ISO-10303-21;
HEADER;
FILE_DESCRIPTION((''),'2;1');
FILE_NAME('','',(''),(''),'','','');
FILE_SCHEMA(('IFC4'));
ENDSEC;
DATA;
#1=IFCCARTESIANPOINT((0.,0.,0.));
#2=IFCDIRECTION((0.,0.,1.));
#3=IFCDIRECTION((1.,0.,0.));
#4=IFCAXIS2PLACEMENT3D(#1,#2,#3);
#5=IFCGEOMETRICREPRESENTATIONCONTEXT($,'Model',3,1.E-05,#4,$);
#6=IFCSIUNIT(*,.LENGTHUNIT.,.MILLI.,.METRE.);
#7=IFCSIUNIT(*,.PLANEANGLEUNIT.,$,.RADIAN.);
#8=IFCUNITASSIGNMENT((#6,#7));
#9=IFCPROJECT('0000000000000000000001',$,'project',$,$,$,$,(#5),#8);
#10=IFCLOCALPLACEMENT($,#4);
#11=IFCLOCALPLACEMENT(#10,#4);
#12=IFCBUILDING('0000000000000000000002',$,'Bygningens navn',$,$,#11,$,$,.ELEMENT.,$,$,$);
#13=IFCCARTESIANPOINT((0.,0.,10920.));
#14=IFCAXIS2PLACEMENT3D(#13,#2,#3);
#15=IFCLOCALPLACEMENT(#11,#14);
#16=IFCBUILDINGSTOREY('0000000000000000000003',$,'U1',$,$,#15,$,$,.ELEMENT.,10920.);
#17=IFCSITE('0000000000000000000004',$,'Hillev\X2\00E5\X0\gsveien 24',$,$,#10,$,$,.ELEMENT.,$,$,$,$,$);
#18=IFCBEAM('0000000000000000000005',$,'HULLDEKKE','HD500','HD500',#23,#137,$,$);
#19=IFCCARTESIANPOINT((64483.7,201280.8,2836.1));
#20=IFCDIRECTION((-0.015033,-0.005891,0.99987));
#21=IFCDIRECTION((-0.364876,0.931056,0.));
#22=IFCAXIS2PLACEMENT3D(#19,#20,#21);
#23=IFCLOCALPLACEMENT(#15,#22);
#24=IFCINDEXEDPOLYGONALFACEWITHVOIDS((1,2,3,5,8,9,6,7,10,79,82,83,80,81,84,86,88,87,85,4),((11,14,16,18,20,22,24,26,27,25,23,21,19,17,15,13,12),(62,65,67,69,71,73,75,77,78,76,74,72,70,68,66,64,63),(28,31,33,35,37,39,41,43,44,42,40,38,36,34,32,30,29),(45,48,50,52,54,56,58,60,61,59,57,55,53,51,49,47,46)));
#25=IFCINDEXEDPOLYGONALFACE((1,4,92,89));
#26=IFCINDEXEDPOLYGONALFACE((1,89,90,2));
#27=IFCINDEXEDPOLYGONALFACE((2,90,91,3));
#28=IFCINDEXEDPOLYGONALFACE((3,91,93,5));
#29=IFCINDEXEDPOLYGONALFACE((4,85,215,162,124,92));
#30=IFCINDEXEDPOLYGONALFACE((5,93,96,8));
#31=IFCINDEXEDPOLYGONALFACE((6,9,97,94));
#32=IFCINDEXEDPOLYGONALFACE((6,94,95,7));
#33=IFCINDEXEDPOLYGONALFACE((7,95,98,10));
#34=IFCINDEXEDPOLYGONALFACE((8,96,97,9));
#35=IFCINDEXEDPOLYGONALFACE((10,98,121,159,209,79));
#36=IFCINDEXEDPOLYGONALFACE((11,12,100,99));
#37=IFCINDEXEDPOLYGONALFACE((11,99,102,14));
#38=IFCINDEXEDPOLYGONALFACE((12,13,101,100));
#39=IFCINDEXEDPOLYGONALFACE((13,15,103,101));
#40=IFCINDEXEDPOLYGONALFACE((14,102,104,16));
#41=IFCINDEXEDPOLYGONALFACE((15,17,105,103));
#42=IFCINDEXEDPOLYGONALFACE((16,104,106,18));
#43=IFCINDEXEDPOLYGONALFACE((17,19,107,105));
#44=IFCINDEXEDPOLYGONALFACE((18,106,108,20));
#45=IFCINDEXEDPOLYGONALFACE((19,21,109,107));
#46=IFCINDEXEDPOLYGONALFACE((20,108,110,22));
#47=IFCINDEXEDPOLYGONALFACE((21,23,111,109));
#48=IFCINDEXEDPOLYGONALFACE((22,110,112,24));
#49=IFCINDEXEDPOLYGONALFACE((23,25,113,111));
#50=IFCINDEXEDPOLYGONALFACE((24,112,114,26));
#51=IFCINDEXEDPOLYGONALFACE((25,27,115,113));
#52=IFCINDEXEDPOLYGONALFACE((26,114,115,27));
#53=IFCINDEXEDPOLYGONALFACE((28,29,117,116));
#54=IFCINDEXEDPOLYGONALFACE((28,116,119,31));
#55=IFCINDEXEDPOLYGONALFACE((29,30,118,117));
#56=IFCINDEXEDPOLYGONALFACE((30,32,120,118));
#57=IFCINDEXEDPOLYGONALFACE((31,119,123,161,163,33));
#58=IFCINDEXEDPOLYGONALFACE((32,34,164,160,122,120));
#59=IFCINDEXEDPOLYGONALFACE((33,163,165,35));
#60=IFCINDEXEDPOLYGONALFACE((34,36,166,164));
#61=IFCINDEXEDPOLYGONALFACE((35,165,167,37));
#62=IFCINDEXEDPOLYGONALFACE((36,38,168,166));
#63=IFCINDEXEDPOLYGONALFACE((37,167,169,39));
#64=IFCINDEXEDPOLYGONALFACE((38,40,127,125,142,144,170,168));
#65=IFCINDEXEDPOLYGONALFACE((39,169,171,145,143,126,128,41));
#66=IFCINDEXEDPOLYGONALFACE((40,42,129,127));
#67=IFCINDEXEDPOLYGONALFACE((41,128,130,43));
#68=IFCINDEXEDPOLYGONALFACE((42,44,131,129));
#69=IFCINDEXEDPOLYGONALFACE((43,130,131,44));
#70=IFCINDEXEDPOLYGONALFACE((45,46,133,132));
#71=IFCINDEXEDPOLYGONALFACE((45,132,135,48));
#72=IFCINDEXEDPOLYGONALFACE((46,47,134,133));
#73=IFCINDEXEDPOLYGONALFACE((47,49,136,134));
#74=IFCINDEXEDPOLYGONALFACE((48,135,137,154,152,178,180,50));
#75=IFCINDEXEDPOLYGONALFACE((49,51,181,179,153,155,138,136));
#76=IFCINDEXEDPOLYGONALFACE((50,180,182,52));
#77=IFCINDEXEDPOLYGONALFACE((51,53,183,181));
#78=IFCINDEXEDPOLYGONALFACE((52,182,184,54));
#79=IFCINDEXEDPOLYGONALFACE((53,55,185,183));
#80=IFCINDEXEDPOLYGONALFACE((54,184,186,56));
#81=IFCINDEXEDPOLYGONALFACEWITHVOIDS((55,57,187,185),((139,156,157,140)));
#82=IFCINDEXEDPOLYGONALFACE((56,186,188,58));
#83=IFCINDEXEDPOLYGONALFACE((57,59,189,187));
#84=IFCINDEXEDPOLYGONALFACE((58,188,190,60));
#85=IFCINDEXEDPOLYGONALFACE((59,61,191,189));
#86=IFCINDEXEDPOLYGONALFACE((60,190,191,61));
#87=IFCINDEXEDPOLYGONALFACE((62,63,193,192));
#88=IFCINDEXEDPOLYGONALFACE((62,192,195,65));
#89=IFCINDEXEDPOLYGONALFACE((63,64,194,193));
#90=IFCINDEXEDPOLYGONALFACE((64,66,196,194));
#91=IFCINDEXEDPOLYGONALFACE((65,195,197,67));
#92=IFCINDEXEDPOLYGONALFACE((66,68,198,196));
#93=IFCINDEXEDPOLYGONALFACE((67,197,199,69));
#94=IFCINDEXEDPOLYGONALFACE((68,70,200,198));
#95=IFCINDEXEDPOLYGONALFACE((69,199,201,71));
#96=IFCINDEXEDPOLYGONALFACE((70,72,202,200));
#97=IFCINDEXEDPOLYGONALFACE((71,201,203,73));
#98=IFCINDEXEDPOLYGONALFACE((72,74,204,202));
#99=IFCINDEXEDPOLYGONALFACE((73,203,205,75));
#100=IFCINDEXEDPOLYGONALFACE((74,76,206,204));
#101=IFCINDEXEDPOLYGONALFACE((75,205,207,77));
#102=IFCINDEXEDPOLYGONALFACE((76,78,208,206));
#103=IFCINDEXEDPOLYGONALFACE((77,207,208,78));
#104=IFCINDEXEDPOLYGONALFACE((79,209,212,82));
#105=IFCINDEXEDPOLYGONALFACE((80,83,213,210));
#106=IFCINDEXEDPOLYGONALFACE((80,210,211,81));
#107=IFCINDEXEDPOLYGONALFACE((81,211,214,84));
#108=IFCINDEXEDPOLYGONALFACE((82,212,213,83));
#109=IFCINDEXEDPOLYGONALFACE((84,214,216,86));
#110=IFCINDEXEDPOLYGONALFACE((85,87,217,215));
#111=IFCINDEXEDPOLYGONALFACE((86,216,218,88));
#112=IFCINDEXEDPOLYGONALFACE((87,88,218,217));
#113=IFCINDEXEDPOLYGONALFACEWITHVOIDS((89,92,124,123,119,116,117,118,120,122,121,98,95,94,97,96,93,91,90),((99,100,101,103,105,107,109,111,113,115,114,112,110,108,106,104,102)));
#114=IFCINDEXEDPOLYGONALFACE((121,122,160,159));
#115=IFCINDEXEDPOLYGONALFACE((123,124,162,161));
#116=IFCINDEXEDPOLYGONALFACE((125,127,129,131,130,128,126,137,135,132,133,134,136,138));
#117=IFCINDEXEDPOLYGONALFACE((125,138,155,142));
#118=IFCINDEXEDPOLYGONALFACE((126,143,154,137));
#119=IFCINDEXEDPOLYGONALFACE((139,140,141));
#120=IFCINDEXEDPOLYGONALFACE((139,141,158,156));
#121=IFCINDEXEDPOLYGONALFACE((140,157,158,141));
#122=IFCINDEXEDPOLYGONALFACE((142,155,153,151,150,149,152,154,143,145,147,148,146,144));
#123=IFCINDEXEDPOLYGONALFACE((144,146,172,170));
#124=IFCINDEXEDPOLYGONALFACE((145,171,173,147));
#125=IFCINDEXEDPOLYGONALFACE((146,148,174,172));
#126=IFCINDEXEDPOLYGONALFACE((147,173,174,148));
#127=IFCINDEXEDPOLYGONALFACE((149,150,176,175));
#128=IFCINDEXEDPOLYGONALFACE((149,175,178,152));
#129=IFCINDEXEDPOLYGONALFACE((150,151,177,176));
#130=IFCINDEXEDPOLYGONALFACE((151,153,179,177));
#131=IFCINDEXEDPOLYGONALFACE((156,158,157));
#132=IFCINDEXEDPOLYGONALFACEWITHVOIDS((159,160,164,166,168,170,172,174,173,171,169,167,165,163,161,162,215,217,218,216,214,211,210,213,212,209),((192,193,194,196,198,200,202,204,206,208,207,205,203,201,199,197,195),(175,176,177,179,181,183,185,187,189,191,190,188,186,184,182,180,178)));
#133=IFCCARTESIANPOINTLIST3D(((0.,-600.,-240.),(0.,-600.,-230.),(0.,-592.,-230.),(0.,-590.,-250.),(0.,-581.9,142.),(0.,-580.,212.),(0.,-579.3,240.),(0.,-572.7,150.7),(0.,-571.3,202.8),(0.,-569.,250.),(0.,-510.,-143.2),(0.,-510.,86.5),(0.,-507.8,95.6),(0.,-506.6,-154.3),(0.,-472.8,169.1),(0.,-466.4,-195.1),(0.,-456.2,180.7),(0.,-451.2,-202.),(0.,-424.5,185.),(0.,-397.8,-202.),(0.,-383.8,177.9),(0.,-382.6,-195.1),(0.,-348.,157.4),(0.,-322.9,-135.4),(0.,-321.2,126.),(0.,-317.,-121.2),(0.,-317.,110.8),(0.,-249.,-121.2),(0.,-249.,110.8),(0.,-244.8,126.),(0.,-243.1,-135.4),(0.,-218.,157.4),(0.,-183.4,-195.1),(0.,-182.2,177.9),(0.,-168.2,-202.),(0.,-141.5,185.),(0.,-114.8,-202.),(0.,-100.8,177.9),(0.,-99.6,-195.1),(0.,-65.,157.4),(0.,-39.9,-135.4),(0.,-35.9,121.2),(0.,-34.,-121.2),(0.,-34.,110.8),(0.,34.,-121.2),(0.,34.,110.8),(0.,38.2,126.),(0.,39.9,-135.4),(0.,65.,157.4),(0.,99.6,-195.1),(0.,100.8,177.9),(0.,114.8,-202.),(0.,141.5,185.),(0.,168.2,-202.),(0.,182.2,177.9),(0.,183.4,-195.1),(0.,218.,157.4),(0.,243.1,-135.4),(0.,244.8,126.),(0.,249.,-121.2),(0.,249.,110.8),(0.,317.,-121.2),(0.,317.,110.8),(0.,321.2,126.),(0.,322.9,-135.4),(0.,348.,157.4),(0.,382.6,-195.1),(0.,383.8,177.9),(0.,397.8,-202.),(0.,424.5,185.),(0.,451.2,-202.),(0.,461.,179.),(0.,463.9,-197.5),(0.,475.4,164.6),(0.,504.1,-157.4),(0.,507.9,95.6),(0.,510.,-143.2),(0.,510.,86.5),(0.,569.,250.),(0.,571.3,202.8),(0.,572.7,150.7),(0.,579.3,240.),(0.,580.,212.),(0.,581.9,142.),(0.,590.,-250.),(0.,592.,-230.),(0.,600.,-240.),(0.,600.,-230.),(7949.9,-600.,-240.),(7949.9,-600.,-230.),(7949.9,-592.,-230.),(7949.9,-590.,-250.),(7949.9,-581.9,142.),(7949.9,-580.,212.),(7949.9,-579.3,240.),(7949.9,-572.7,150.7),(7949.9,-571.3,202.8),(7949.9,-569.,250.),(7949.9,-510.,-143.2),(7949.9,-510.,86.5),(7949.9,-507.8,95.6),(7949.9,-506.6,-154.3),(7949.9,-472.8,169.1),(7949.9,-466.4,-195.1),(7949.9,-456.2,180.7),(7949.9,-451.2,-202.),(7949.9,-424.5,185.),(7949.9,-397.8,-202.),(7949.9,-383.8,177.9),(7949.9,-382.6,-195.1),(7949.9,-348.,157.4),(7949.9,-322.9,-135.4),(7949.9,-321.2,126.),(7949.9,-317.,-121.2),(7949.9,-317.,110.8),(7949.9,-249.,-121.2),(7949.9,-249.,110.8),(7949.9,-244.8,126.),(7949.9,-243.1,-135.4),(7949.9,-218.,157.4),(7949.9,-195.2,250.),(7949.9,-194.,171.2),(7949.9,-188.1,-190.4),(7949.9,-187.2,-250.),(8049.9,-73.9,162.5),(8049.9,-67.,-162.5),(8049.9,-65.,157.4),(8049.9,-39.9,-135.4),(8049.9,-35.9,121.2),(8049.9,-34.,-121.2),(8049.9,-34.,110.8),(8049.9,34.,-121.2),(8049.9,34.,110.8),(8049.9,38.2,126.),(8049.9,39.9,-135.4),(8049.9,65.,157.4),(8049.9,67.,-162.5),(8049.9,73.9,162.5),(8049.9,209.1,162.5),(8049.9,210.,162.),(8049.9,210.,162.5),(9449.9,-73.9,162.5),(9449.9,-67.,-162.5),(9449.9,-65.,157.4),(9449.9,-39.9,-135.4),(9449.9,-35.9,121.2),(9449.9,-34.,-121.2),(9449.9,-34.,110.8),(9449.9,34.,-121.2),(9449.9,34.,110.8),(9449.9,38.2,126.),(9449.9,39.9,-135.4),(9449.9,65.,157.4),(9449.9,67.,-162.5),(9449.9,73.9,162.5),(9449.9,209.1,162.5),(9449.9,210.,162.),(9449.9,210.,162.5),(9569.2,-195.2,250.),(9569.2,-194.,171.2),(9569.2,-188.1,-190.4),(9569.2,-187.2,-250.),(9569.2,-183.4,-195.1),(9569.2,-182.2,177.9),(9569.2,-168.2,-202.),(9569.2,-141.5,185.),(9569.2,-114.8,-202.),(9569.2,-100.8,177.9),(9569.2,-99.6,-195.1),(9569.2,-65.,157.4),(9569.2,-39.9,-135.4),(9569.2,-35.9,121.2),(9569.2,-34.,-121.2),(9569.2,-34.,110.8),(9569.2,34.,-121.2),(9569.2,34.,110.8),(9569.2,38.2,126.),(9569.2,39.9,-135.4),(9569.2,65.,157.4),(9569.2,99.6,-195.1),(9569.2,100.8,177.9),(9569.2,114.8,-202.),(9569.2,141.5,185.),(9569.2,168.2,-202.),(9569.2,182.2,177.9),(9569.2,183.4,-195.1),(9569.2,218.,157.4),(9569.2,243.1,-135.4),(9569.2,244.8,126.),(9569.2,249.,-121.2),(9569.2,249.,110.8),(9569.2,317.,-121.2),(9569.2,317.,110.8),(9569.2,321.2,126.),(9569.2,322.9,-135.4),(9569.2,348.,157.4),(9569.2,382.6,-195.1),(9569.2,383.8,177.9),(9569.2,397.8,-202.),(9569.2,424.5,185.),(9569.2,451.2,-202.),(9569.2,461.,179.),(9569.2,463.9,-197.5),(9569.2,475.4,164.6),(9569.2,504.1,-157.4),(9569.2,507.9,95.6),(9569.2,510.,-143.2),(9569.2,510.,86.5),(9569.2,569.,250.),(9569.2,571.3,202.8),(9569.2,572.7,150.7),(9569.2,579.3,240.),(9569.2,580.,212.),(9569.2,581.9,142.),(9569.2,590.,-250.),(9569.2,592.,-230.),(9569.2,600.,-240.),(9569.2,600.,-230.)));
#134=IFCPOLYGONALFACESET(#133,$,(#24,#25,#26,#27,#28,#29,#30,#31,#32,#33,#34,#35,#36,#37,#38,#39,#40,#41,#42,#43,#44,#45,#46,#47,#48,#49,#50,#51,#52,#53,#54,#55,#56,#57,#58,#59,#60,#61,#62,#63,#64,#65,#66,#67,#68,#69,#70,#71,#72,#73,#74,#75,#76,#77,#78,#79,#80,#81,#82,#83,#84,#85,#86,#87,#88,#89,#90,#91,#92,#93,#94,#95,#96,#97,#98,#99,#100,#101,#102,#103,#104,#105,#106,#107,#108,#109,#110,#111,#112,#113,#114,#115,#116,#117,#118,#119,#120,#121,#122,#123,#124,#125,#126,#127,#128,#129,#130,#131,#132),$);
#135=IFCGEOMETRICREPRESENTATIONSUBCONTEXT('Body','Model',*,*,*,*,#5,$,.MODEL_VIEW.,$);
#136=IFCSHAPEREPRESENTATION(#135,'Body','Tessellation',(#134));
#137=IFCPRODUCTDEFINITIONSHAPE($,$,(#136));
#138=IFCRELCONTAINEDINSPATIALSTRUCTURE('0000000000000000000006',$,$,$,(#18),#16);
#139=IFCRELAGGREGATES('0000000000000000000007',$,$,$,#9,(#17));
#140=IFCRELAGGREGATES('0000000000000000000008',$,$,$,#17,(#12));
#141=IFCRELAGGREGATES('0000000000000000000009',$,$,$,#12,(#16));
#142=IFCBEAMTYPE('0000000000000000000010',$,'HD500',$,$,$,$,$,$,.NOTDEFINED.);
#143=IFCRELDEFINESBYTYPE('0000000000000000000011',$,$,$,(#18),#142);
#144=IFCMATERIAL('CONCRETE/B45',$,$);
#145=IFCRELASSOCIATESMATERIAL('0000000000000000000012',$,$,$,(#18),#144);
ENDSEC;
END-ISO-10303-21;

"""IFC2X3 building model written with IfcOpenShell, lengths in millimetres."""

from ifc_helpers import new_model, si_unit, frame, origin_with_axes, place, context, subcontext, project, spatial, polyline, outline, extrude, boolean, material, type_object, element, save


model = new_model("IFC2X3")

# Units and contexts
model_context = context("Model", 3, precision=1e-05, world=origin_with_axes())
body_context = subcontext(model_context, "Body", "Model", "MODEL_VIEW")
ifc_project = project(units=[si_unit("LENGTHUNIT", "METRE", prefix="MILLI"), si_unit("PLANEANGLEUNIT", "RADIAN")], contexts=[model_context])

# Site, building, storey
site_placement = place(None, origin_with_axes())
site = spatial("IfcSite", under=ifc_project, at=site_placement, Name="Hillevågsveien 24", CompositionType="ELEMENT")
building_placement = place(site_placement, origin_with_axes())
building = spatial("IfcBuilding", under=site, at=building_placement, Name="Bygningens navn", CompositionType="ELEMENT")
storey_placement = place(building_placement, frame((0.0, 0.0, 10920.0), z_axis=(0.0, 0.0, 1.0), x_axis=(1.0, 0.0, 0.0)))
storey = spatial("IfcBuildingStorey", under=building, at=storey_placement, Name="U1", CompositionType="ELEMENT", Elevation=10920.0)

# Beam
ifc_material_1 = material(Name="CONCRETE/B45")
beam_type_1 = type_object("IfcBeamType", Name="HD500", PredefinedType="NOTDEFINED")
beam_1_placement = place(storey_placement, frame((64483.7, 201280.8, 2836.1), z_axis=(-0.015033, -0.005891, 0.99987), x_axis=(-0.364876, 0.931056, 0.0)))
element("IfcBeam", 1, at=beam_1_placement, inside=storey, type_object=beam_type_1, material=ifc_material_1, Name="HULLDEKKE", Description="HD500", ObjectType="HD500", context=body_context, shape_type="CSG", body=[
    boolean("DIFFERENCE", boolean("DIFFERENCE", boolean("DIFFERENCE", extrude(outline(polyline([(581.9, 142.0), (592.0, -230.0), (600.0, -230.0), (600.0, -240.0), (590.0, -250.0), (-590.0, -250.0), (-600.0, -240.0), (-600.0, -230.0), (-592.0, -230.0), (-581.9, 142.0), (-572.7, 150.7), (-571.3, 202.8), (-580.0, 212.0), (-579.3, 240.0), (-569.0, 250.0), (569.0, 250.0), (579.3, 240.0), (580.0, 212.0), (571.3, 202.8), (572.7, 150.7), (581.9, 142.0)]), holes=[polyline([(466.4, -195.1), (506.6, -154.3), (510.0, -143.2), (510.0, 86.5), (507.8, 95.6), (472.8, 169.1), (456.2, 180.7), (424.5, 185.0), (383.8, 177.9), (348.0, 157.4), (321.2, 126.0), (317.0, 110.8), (317.0, -121.2), (322.9, -135.4), (382.6, -195.1), (397.8, -202.0), (451.2, -202.0), (466.4, -195.1)]), polyline([(183.4, -195.1), (243.1, -135.4), (249.0, -121.2), (249.0, 110.8), (244.8, 126.0), (218.0, 157.4), (182.2, 177.9), (141.5, 185.0), (100.8, 177.9), (65.0, 157.4), (35.9, 121.2), (34.0, 110.8), (34.0, -121.2), (39.9, -135.4), (99.6, -195.1), (114.8, -202.0), (168.2, -202.0), (183.4, -195.1)]), polyline([(-99.6, -195.1), (-39.9, -135.4), (-34.0, -121.2), (-34.0, 110.8), (-38.2, 126.0), (-65.0, 157.4), (-100.8, 177.9), (-141.5, 185.0), (-182.2, 177.9), (-218.0, 157.4), (-244.8, 126.0), (-249.0, 110.8), (-249.0, -121.2), (-243.1, -135.4), (-183.4, -195.1), (-168.2, -202.0), (-114.8, -202.0), (-99.6, -195.1)]), polyline([(-382.6, -195.1), (-322.9, -135.4), (-317.0, -121.2), (-317.0, 110.8), (-321.2, 126.0), (-348.0, 157.4), (-383.8, 177.9), (-424.5, 185.0), (-461.0, 179.0), (-475.4, 164.6), (-507.9, 95.6), (-510.0, 86.5), (-510.0, -143.2), (-504.1, -157.4), (-463.9, -197.5), (-451.2, -202.0), (-397.8, -202.0), (-382.6, -195.1)])]), frame((9569.2, 0.0, 0.0), z_axis=(-1.0, 0.0, 0.0), x_axis=(0.0, -1.0, 0.0)), (0.0, 0.0, 1.0), 9569.2), extrude(outline(polyline([(0.0, 0.0), (804.4, 0.0), (804.4, 1620.0), (4.4, 1620.0), (4.4, 0.0), (0.0, 0.0)])), frame((7949.9, -999.7, 245.7), z_axis=(0.0, 0.016146, -0.99987), x_axis=(-0.000001, 0.99987, 0.016146)), (0.0, 0.0, 1.0), 524.0)), extrude(outline(polyline([(0.0, 0.0), (1400.0, 0.0), (1400.0, 868.0), (0.0, 868.0), (0.0, 0.0)])), frame((8049.9, 210.0, 162.5), z_axis=(0.0, 0.0, -1.0), x_axis=(1.0, 0.0, 0.0)), (0.0, 0.0, 1.0), 325.0)), extrude(outline(polyline([(0.0, 0.0), (1400.0, 0.0), (1400.0, 868.0), (0.0, 868.0), (0.0, 0.0)])), frame((8049.9, 210.0, 162.5), z_axis=(0.0, 0.0, -1.0), x_axis=(1.0, 0.0, 0.0)), (0.0, 0.0, 1.0), 325.0)),
])

save(model, "model.ifc")
